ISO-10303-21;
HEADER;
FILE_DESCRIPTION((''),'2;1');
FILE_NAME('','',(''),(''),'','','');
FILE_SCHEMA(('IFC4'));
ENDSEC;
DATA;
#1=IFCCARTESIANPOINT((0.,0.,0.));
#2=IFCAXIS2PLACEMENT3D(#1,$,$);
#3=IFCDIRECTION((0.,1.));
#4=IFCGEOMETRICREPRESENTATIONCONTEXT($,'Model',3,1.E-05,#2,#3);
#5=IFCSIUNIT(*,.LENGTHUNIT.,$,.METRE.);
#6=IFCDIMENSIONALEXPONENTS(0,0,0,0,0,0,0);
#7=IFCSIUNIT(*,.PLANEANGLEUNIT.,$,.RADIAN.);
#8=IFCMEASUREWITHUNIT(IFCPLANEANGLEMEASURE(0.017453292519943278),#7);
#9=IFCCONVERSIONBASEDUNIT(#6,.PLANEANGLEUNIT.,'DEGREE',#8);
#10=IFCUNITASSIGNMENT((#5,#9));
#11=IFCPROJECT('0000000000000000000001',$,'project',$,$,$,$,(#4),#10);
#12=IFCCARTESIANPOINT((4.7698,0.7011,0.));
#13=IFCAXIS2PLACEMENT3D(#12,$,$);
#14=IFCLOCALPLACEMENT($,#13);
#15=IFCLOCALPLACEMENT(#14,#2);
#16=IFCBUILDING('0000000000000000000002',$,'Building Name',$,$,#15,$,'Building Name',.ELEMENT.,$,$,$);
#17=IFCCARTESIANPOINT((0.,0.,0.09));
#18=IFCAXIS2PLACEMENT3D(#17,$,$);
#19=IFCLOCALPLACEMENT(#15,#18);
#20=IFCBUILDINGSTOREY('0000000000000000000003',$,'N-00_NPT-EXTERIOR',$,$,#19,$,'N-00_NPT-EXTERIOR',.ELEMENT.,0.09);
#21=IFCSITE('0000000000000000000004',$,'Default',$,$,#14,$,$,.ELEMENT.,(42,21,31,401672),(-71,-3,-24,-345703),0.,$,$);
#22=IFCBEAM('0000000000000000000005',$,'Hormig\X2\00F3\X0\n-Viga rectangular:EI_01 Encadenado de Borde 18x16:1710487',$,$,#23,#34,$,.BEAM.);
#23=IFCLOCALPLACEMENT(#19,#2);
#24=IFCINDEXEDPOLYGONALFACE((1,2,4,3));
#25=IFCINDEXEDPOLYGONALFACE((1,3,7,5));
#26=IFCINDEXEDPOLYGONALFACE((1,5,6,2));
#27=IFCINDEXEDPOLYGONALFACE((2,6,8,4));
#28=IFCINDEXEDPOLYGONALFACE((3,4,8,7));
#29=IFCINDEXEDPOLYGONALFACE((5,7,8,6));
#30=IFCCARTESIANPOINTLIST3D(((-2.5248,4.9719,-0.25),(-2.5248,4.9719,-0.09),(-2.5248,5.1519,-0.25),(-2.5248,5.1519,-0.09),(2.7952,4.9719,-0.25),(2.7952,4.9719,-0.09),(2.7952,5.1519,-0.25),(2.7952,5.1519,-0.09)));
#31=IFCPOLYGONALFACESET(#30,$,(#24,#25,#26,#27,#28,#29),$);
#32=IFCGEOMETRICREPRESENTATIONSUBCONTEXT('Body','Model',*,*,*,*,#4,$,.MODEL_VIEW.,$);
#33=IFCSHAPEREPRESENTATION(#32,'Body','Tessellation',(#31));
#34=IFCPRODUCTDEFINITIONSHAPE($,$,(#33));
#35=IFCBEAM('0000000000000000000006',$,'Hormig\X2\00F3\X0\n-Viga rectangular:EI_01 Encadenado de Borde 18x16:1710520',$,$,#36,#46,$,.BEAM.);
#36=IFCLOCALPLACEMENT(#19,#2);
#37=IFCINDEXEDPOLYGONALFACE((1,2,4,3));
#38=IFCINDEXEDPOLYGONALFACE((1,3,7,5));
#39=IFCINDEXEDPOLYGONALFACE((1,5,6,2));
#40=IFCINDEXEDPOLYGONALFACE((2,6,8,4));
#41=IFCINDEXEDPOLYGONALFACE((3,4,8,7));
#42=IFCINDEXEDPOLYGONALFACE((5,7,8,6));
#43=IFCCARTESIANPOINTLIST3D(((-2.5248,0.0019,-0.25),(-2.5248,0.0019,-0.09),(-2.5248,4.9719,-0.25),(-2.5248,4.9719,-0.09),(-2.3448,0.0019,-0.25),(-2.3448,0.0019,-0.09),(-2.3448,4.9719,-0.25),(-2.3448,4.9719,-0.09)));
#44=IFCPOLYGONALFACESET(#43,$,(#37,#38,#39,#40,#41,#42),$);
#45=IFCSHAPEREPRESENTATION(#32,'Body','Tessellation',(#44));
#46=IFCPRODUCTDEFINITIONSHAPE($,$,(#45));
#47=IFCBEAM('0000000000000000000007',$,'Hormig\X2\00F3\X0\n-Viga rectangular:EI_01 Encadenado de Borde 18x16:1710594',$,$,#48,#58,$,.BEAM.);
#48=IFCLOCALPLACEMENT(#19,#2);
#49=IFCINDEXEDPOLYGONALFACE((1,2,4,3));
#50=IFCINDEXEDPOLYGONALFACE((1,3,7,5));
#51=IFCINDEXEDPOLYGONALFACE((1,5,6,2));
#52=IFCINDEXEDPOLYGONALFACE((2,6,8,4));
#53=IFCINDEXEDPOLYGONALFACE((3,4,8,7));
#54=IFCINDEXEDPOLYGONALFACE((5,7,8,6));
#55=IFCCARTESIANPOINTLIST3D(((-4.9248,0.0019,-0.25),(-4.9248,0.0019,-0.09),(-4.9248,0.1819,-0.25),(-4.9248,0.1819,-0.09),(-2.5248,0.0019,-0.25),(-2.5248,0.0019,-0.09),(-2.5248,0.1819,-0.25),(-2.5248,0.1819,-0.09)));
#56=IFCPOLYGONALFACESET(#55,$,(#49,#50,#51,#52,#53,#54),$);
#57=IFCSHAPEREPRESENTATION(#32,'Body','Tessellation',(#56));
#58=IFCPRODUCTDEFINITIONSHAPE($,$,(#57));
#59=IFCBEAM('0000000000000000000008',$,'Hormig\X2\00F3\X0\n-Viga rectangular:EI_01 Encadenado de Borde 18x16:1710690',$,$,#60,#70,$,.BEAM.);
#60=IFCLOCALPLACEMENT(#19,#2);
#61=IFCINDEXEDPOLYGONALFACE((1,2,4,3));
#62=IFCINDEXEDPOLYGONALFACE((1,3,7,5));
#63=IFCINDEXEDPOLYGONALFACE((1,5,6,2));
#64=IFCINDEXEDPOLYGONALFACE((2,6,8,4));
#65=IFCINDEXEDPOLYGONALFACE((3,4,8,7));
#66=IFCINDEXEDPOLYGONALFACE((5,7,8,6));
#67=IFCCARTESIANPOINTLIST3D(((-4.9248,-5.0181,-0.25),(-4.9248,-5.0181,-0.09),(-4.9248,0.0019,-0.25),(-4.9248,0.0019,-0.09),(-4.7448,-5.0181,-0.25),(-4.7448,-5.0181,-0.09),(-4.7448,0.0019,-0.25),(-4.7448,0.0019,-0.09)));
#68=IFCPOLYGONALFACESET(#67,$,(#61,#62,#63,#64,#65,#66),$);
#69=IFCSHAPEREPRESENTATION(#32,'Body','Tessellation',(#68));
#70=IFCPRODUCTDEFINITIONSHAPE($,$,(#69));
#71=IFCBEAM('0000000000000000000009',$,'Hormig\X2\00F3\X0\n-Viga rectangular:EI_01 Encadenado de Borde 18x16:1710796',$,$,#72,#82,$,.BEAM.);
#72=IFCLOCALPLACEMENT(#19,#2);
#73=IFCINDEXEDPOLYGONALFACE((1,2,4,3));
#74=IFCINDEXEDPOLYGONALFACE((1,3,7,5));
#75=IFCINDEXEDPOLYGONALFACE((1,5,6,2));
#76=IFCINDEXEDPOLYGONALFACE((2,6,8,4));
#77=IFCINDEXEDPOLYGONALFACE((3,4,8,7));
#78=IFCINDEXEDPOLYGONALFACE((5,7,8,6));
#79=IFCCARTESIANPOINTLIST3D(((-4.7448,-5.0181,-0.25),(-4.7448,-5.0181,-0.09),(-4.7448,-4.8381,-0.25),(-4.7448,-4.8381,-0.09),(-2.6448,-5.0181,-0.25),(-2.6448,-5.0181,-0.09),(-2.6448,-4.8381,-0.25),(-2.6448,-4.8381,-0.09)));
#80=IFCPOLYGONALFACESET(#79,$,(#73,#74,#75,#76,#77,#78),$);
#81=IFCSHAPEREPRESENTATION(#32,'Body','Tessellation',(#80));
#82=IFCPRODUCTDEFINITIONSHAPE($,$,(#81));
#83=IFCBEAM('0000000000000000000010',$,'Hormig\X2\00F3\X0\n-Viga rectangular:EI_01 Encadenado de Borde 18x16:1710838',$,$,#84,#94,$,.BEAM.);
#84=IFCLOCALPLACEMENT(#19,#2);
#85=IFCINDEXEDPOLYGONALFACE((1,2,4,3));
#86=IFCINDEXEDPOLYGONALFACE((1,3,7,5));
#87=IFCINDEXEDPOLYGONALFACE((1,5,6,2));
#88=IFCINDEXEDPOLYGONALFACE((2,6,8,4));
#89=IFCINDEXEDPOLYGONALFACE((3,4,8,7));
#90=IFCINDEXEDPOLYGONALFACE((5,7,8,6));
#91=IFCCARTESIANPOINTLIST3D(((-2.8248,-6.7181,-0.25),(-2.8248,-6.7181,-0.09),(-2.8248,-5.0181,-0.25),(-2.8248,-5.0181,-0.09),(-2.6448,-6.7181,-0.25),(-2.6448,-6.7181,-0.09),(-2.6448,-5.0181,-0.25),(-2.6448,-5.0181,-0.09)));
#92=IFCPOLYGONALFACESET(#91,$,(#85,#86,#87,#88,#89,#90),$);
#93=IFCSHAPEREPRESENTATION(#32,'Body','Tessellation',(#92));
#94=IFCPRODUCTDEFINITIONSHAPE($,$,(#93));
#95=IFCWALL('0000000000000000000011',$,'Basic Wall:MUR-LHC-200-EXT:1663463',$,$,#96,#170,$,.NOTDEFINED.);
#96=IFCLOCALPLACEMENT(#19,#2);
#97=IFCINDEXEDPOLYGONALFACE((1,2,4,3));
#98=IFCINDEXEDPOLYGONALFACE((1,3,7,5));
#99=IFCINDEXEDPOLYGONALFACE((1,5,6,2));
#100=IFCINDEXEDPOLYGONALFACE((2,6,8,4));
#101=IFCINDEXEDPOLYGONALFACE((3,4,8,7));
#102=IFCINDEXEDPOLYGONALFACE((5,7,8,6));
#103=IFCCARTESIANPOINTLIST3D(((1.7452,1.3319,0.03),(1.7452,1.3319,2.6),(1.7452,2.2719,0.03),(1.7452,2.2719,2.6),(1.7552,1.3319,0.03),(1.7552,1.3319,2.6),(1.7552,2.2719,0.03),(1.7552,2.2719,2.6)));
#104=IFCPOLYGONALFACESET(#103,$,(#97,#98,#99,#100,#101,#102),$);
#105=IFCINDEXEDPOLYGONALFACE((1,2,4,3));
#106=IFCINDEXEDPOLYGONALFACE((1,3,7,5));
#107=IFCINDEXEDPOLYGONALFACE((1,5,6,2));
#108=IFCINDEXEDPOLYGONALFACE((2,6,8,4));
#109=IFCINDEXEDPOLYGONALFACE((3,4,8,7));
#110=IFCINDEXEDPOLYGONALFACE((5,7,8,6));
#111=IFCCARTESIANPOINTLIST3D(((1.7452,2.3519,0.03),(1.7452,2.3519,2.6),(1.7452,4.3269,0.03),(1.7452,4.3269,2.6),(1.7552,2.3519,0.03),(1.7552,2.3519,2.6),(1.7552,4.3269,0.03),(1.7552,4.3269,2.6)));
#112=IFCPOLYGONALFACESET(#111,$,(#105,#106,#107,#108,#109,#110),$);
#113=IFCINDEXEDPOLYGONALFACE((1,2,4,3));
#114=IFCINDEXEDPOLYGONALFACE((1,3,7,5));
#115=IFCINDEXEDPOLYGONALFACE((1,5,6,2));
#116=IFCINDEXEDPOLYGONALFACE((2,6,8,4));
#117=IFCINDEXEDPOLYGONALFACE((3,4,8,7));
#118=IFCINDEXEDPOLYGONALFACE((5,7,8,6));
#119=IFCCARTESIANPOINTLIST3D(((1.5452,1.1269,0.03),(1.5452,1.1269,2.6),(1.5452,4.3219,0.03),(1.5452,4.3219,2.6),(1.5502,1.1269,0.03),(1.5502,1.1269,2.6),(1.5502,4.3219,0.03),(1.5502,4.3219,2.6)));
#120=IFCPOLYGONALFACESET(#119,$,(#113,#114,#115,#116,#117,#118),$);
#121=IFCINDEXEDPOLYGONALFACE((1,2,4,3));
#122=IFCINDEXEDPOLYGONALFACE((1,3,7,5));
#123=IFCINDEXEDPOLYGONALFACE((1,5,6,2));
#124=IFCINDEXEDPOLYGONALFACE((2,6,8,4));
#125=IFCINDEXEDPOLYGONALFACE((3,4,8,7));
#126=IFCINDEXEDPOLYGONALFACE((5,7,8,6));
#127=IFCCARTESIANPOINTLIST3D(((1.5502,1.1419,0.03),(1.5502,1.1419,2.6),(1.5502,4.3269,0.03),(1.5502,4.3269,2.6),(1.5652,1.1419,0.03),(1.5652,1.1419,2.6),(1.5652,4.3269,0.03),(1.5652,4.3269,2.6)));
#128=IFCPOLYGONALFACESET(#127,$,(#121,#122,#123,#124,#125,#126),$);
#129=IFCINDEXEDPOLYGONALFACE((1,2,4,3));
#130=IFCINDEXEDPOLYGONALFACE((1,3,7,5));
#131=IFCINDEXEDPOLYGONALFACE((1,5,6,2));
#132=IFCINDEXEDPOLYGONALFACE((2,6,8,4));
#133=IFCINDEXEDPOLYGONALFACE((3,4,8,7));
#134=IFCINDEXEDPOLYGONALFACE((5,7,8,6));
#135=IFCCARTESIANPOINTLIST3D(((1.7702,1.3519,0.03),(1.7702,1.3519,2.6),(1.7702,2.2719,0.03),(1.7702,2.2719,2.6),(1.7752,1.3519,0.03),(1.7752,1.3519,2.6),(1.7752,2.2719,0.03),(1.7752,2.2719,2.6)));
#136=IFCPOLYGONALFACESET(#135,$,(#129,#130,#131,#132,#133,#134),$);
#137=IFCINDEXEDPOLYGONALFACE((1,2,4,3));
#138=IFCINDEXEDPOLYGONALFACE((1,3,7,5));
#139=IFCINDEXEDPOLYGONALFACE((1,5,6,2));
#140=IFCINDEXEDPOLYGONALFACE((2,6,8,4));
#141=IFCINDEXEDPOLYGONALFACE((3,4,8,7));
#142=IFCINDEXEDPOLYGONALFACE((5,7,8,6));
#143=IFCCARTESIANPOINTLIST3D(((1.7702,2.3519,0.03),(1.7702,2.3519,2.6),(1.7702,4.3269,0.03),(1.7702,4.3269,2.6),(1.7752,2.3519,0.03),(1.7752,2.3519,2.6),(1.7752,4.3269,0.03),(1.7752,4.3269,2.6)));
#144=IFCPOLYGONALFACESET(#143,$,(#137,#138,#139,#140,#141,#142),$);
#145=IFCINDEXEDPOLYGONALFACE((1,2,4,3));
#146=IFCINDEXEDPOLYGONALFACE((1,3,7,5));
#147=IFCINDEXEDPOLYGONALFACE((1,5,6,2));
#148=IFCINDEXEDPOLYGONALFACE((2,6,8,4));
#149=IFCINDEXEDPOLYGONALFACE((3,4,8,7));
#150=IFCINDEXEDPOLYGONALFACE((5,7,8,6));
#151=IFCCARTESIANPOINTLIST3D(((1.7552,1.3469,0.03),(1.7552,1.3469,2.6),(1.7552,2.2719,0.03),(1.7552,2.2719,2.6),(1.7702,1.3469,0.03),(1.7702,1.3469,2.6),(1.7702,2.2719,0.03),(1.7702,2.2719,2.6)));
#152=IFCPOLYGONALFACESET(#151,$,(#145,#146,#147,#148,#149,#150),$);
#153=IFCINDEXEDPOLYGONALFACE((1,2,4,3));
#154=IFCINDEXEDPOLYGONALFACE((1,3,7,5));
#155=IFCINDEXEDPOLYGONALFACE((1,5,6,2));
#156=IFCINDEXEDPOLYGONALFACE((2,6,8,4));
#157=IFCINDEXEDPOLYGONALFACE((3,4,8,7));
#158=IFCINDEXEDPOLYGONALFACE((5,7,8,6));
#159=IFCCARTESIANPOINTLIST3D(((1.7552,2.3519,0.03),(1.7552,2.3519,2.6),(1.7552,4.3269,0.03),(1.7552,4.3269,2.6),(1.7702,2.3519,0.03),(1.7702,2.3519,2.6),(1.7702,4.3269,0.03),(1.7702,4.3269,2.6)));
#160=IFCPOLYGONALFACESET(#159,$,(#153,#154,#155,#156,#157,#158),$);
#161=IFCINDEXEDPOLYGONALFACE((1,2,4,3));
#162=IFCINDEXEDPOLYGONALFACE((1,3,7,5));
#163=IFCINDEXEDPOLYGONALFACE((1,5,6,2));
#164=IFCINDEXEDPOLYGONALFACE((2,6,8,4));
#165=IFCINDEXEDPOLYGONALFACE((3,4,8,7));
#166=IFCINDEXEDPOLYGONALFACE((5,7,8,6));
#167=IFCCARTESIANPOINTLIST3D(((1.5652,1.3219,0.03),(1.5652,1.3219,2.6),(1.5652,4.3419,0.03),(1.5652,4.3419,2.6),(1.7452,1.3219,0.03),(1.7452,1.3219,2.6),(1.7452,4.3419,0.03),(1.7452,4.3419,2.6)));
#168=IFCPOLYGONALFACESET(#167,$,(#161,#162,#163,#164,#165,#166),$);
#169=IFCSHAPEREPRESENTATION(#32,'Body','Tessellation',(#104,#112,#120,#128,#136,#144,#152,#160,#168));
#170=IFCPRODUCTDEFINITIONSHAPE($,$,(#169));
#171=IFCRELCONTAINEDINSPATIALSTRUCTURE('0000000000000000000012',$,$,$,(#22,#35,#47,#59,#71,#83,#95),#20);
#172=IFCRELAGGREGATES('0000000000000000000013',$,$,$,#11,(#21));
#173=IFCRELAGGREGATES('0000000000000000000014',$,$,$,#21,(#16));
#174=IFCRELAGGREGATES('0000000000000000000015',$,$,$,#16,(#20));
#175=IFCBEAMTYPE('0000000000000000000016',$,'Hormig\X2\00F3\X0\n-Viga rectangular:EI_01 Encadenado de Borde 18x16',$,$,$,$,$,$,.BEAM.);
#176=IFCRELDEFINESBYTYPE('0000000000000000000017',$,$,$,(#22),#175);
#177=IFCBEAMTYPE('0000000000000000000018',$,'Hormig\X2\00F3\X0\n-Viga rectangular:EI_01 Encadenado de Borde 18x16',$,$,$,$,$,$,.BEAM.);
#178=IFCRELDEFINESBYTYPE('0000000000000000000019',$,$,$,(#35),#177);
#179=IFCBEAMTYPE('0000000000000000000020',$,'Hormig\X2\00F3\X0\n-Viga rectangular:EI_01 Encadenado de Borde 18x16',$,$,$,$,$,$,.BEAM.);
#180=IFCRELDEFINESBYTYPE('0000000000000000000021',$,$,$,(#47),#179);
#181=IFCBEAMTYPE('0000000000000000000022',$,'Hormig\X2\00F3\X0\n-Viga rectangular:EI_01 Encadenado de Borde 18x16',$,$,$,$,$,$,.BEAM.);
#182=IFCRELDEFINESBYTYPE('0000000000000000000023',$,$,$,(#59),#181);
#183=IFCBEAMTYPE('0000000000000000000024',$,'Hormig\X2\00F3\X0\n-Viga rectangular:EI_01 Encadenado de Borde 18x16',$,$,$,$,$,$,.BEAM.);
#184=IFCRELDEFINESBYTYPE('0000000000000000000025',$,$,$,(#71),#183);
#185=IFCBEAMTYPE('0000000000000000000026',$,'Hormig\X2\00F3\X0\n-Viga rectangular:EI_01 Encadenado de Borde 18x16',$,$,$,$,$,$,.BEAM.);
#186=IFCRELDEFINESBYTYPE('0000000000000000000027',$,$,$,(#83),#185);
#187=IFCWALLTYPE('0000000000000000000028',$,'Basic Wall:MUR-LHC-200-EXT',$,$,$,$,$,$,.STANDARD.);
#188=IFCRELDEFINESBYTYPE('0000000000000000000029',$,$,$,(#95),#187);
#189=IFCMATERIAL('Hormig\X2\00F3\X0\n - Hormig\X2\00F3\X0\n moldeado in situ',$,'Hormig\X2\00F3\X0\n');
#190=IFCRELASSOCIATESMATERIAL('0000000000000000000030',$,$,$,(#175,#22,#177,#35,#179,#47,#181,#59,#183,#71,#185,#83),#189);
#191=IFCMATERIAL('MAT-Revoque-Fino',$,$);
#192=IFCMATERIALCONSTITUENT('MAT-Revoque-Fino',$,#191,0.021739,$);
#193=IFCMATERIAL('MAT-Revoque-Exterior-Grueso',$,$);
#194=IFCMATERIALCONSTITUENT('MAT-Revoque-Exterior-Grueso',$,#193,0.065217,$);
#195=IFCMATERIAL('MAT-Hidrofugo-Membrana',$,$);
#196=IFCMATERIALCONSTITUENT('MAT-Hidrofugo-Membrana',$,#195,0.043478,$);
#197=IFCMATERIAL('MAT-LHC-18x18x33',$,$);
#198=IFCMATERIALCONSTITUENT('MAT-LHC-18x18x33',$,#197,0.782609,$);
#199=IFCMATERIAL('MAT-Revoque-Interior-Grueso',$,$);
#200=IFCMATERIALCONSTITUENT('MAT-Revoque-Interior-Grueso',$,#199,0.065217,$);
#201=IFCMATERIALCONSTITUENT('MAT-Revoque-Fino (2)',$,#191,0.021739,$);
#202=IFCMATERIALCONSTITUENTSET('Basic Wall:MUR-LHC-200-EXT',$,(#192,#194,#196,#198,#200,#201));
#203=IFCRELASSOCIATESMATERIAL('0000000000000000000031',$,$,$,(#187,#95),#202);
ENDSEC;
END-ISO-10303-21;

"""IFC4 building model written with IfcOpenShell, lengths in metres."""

from ifc_helpers import new_model, entity, si_unit, converted_unit, direction, frame, origin, place, context, subcontext, project, spatial, indexed_curve, outline, extrude, source, transform, mapped, material, constituent, constituent_set, type_object, type_shapes, element, save


model = new_model("IFC4")

# Units and contexts
model_context = context("Model", 3, precision=1e-05, world=origin(), true_north=direction((0.0, 1.0)))
body_context = subcontext(model_context, "Body", "Model", "MODEL_VIEW")
ifc_project = project(units=[si_unit("LENGTHUNIT", "METRE"), converted_unit("PLANEANGLEUNIT", "DEGREE", entity("IfcPlaneAngleMeasure", 0.017453292519943278), si_unit("PLANEANGLEUNIT", "RADIAN"), dimensions=[0, 0, 0, 0, 0, 0, 0])], contexts=[model_context])

# Site, building, storey
site_placement = place(None, frame((4.7698, 0.7011, 0.0)))
site = spatial("IfcSite", under=ifc_project, at=site_placement, Name="Default", CompositionType="ELEMENT", RefLatitude=(42, 21, 31, 401672), RefLongitude=(-71, -3, -24, -345703), RefElevation=0.0)
building_placement = place(site_placement, origin())
building = spatial("IfcBuilding", under=site, at=building_placement, Name="Building Name", LongName="Building Name", CompositionType="ELEMENT")
storey_placement = place(building_placement, frame((0.0, 0.0, 0.09)))
storey = spatial("IfcBuildingStorey", under=building, at=storey_placement, Name="N-00_NPT-EXTERIOR", LongName="N-00_NPT-EXTERIOR", CompositionType="ELEMENT", Elevation=0.09)

# Beams
ifc_material_1 = material(Name="Hormigón - Hormigón moldeado in situ", Category="Hormigón")
beam_type_1 = type_object("IfcBeamType", Name="Hormigón-Viga rectangular:EI_01 Encadenado de Borde 18x16", PredefinedType="BEAM", material=ifc_material_1)
shared_shape_1 = source(origin(), body_context, "Body", "SweptSolid", [
    extrude(outline(indexed_curve([(-0.08, -0.09), (0.08, -0.09), (0.08, 0.09), (-0.08, 0.09), (-0.08, -0.09)], self_intersect=False)), frame((2.7952, 5.0619, -0.08), z_axis=(-1.0, 0.0, 0.0), x_axis=(0.0, 0.0, -1.0)), (0.0, 0.0, 1.0), 5.32),
])
type_shapes(beam_type_1, [shared_shape_1])
beam_1_placement = place(storey_placement, frame((0.0, 0.0, -0.09)))
element("IfcBeam", 1, at=beam_1_placement, inside=storey, type_object=beam_type_1, material=ifc_material_1, Name="Hormigón-Viga rectangular:EI_01 Encadenado de Borde 18x16:1710487", PredefinedType="BEAM", context=body_context, shape_type="MappedRepresentation", body=[
    mapped(shared_shape_1, transform((0.0, 0.0, 0.0), scale=1.0)),
])
beam_type_2 = type_object("IfcBeamType", Name="Hormigón-Viga rectangular:EI_01 Encadenado de Borde 18x16", PredefinedType="BEAM", material=ifc_material_1)
shared_shape_2 = source(origin(), body_context, "Body", "SweptSolid", [
    extrude(outline(indexed_curve([(-0.09, -0.08), (0.09, -0.08), (0.09, 0.08), (-0.09, 0.08), (-0.09, -0.08)], self_intersect=False)), frame((-2.4348, 4.9719, -0.08), z_axis=(0.0, -1.0, 0.0), x_axis=(-1.0, 0.0, 0.0)), (0.0, 0.0, 1.0), 4.97),
])
type_shapes(beam_type_2, [shared_shape_2])
beam_2_placement = place(storey_placement, frame((0.0, 0.0, -0.09)))
element("IfcBeam", 2, at=beam_2_placement, inside=storey, type_object=beam_type_2, material=ifc_material_1, Name="Hormigón-Viga rectangular:EI_01 Encadenado de Borde 18x16:1710520", PredefinedType="BEAM", context=body_context, shape_type="MappedRepresentation", body=[
    mapped(shared_shape_2, transform((0.0, 0.0, 0.0), scale=1.0)),
])
beam_type_3 = type_object("IfcBeamType", Name="Hormigón-Viga rectangular:EI_01 Encadenado de Borde 18x16", PredefinedType="BEAM", material=ifc_material_1)
shared_shape_3 = source(origin(), body_context, "Body", "SweptSolid", [
    extrude(outline(indexed_curve([(-0.08, -0.09), (0.08, -0.09), (0.08, 0.09), (-0.08, 0.09), (-0.08, -0.09)], self_intersect=False)), frame((-2.5248, 0.0919, -0.08), z_axis=(-1.0, 0.0, 0.0), x_axis=(0.0, 0.0, -1.0)), (0.0, 0.0, 1.0), 2.4),
])
type_shapes(beam_type_3, [shared_shape_3])
beam_3_placement = place(storey_placement, frame((0.0, 0.0, -0.09)))
element("IfcBeam", 3, at=beam_3_placement, inside=storey, type_object=beam_type_3, material=ifc_material_1, Name="Hormigón-Viga rectangular:EI_01 Encadenado de Borde 18x16:1710594", PredefinedType="BEAM", context=body_context, shape_type="MappedRepresentation", body=[
    mapped(shared_shape_3, transform((0.0, 0.0, 0.0), scale=1.0)),
])
beam_type_4 = type_object("IfcBeamType", Name="Hormigón-Viga rectangular:EI_01 Encadenado de Borde 18x16", PredefinedType="BEAM", material=ifc_material_1)
shared_shape_4 = source(origin(), body_context, "Body", "SweptSolid", [
    extrude(outline(indexed_curve([(-0.09, -0.08), (0.09, -0.08), (0.09, 0.08), (-0.09, 0.08), (-0.09, -0.08)], self_intersect=False)), frame((-4.8348, 0.0019, -0.08), z_axis=(0.0, -1.0, 0.0), x_axis=(-1.0, 0.0, 0.0)), (0.0, 0.0, 1.0), 5.02),
])
type_shapes(beam_type_4, [shared_shape_4])
beam_4_placement = place(storey_placement, frame((0.0, 0.0, -0.09)))
element("IfcBeam", 4, at=beam_4_placement, inside=storey, type_object=beam_type_4, material=ifc_material_1, Name="Hormigón-Viga rectangular:EI_01 Encadenado de Borde 18x16:1710690", PredefinedType="BEAM", context=body_context, shape_type="MappedRepresentation", body=[
    mapped(shared_shape_4, transform((0.0, 0.0, 0.0), scale=1.0)),
])
beam_type_5 = type_object("IfcBeamType", Name="Hormigón-Viga rectangular:EI_01 Encadenado de Borde 18x16", PredefinedType="BEAM", material=ifc_material_1)
shared_shape_5 = source(origin(), body_context, "Body", "SweptSolid", [
    extrude(outline(indexed_curve([(-0.08, -0.09), (0.08, -0.09), (0.08, 0.09), (-0.08, 0.09), (-0.08, -0.09)], self_intersect=False)), frame((-4.7448, -4.9281, -0.08), z_axis=(1.0, 0.0, 0.0), x_axis=(0.0, 0.0, -1.0)), (0.0, 0.0, 1.0), 2.1),
])
type_shapes(beam_type_5, [shared_shape_5])
beam_5_placement = place(storey_placement, frame((0.0, 0.0, -0.09)))
element("IfcBeam", 5, at=beam_5_placement, inside=storey, type_object=beam_type_5, material=ifc_material_1, Name="Hormigón-Viga rectangular:EI_01 Encadenado de Borde 18x16:1710796", PredefinedType="BEAM", context=body_context, shape_type="MappedRepresentation", body=[
    mapped(shared_shape_5, transform((0.0, 0.0, 0.0), scale=1.0)),
])
beam_type_6 = type_object("IfcBeamType", Name="Hormigón-Viga rectangular:EI_01 Encadenado de Borde 18x16", PredefinedType="BEAM", material=ifc_material_1)
shared_shape_6 = source(origin(), body_context, "Body", "SweptSolid", [
    extrude(outline(indexed_curve([(-0.09, -0.08), (0.09, -0.08), (0.09, 0.08), (-0.09, 0.08), (-0.09, -0.08)], self_intersect=False)), frame((-2.7348, -5.0181, -0.08), z_axis=(0.0, -1.0, 0.0), x_axis=(-1.0, 0.0, 0.0)), (0.0, 0.0, 1.0), 1.7),
])
type_shapes(beam_type_6, [shared_shape_6])
beam_6_placement = place(storey_placement, frame((0.0, 0.0, -0.09)))
element("IfcBeam", 6, at=beam_6_placement, inside=storey, type_object=beam_type_6, material=ifc_material_1, Name="Hormigón-Viga rectangular:EI_01 Encadenado de Borde 18x16:1710838", PredefinedType="BEAM", context=body_context, shape_type="MappedRepresentation", body=[
    mapped(shared_shape_6, transform((0.0, 0.0, 0.0), scale=1.0)),
])

# Shared definitions
ifc_material_2 = material(Name="MAT-Revoque-Fino")
ifc_constituent_1 = constituent(ifc_material_2, Name="MAT-Revoque-Fino", fraction=0.021739)
ifc_material_3 = material(Name="MAT-Revoque-Exterior-Grueso")
ifc_constituent_2 = constituent(ifc_material_3, Name="MAT-Revoque-Exterior-Grueso", fraction=0.065217)
ifc_material_4 = material(Name="MAT-Hidrofugo-Membrana")
ifc_constituent_3 = constituent(ifc_material_4, Name="MAT-Hidrofugo-Membrana", fraction=0.043478)
ifc_material_5 = material(Name="MAT-LHC-18x18x33")
ifc_constituent_4 = constituent(ifc_material_5, Name="MAT-LHC-18x18x33", fraction=0.782609)
ifc_material_6 = material(Name="MAT-Revoque-Interior-Grueso")
ifc_constituent_5 = constituent(ifc_material_6, Name="MAT-Revoque-Interior-Grueso", fraction=0.065217)
ifc_constituent_6 = constituent(ifc_material_2, Name="MAT-Revoque-Fino (2)", fraction=0.021739)
ifc_constituent_set_1 = constituent_set(constituents=[ifc_constituent_1, ifc_constituent_2, ifc_constituent_3, ifc_constituent_4, ifc_constituent_5, ifc_constituent_6], Name="Basic Wall:MUR-LHC-200-EXT")
wall_type_1 = type_object("IfcWallType", Name="Basic Wall:MUR-LHC-200-EXT", PredefinedType="STANDARD", material=ifc_constituent_set_1)

# Wall
wall_1_placement = place(storey_placement, frame((1.6602, 4.3219, 0.03), z_axis=(0.0, 0.0, 1.0), x_axis=(0.0, -1.0, 0.0)))
element("IfcWall", 7, at=wall_1_placement, inside=storey, type_object=wall_type_1, material=ifc_constituent_set_1, Name="Basic Wall:MUR-LHC-200-EXT:1663463", PredefinedType="NOTDEFINED", context=body_context, shape_type="SweptSolid", body=[
    extrude(outline(indexed_curve([(-0.47, -0.005), (0.47, -0.005), (0.47, 0.005), (-0.47, 0.005), (-0.47, -0.005)], self_intersect=False)), frame((2.52, 0.09, 0.0), z_axis=(0.0, 0.0, 1.0), x_axis=(-1.0, 0.0, 0.0)), (0.0, 0.0, 1.0), 2.57),
    extrude(outline(indexed_curve([(-0.9875, -0.005), (0.9875, -0.005), (0.9875, 0.005), (-0.9875, 0.005), (-0.9875, -0.005)], self_intersect=False)), frame((0.9825, 0.09, 0.0)), (0.0, 0.0, 1.0), 2.57),
    extrude(outline(indexed_curve([(-0.0025, -1.5975), (0.0025, -1.5975), (0.0025, 1.5975), (-0.0025, 1.5975), (-0.0025, -1.5975)], self_intersect=False)), frame((1.5975, -0.1125, 0.0), z_axis=(0.0, 0.0, 1.0), x_axis=(0.0, -1.0, 0.0)), (0.0, 0.0, 1.0), 2.57),
    extrude(outline(indexed_curve([(-0.0075, -1.5925), (0.0075, -1.5925), (0.0075, 1.5925), (-0.0075, 1.5925), (-0.0075, -1.5925)], self_intersect=False)), frame((1.5875, -0.1025, 0.0), z_axis=(0.0, 0.0, 1.0), x_axis=(0.0, 1.0, 0.0)), (0.0, 0.0, 1.0), 2.57),
    extrude(outline(indexed_curve([(-0.46, -0.0025), (0.46, -0.0025), (0.46, 0.0025), (-0.46, 0.0025), (-0.46, -0.0025)], self_intersect=False)), frame((2.51, 0.1125, 0.0), z_axis=(0.0, 0.0, 1.0), x_axis=(-1.0, 0.0, 0.0)), (0.0, 0.0, 1.0), 2.57),
    extrude(outline(indexed_curve([(-0.9875, -0.0025), (0.9875, -0.0025), (0.9875, 0.0025), (-0.9875, 0.0025), (-0.9875, -0.0025)], self_intersect=False)), frame((0.9825, 0.1125, 0.0)), (0.0, 0.0, 1.0), 2.57),
    extrude(outline(indexed_curve([(-0.4625, -0.0075), (0.4625, -0.0075), (0.4625, 0.0075), (-0.4625, 0.0075), (-0.4625, -0.0075)], self_intersect=False)), frame((2.5125, 0.1025, 0.0), z_axis=(0.0, 0.0, 1.0), x_axis=(-1.0, 0.0, 0.0)), (0.0, 0.0, 1.0), 2.57),
    extrude(outline(indexed_curve([(-0.9875, -0.0075), (0.9875, -0.0075), (0.9875, 0.0075), (-0.9875, 0.0075), (-0.9875, -0.0075)], self_intersect=False)), frame((0.9825, 0.1025, 0.0)), (0.0, 0.0, 1.0), 2.57),
    extrude(outline(indexed_curve([(-0.09, -1.51), (0.09, -1.51), (0.09, 1.51), (-0.09, 1.51), (-0.09, -1.51)], self_intersect=False)), frame((1.49, -0.005, 0.0), z_axis=(0.0, 0.0, 1.0), x_axis=(0.0, -1.0, 0.0)), (0.0, 0.0, 1.0), 2.57),
])

save(model, "model.ifc")
